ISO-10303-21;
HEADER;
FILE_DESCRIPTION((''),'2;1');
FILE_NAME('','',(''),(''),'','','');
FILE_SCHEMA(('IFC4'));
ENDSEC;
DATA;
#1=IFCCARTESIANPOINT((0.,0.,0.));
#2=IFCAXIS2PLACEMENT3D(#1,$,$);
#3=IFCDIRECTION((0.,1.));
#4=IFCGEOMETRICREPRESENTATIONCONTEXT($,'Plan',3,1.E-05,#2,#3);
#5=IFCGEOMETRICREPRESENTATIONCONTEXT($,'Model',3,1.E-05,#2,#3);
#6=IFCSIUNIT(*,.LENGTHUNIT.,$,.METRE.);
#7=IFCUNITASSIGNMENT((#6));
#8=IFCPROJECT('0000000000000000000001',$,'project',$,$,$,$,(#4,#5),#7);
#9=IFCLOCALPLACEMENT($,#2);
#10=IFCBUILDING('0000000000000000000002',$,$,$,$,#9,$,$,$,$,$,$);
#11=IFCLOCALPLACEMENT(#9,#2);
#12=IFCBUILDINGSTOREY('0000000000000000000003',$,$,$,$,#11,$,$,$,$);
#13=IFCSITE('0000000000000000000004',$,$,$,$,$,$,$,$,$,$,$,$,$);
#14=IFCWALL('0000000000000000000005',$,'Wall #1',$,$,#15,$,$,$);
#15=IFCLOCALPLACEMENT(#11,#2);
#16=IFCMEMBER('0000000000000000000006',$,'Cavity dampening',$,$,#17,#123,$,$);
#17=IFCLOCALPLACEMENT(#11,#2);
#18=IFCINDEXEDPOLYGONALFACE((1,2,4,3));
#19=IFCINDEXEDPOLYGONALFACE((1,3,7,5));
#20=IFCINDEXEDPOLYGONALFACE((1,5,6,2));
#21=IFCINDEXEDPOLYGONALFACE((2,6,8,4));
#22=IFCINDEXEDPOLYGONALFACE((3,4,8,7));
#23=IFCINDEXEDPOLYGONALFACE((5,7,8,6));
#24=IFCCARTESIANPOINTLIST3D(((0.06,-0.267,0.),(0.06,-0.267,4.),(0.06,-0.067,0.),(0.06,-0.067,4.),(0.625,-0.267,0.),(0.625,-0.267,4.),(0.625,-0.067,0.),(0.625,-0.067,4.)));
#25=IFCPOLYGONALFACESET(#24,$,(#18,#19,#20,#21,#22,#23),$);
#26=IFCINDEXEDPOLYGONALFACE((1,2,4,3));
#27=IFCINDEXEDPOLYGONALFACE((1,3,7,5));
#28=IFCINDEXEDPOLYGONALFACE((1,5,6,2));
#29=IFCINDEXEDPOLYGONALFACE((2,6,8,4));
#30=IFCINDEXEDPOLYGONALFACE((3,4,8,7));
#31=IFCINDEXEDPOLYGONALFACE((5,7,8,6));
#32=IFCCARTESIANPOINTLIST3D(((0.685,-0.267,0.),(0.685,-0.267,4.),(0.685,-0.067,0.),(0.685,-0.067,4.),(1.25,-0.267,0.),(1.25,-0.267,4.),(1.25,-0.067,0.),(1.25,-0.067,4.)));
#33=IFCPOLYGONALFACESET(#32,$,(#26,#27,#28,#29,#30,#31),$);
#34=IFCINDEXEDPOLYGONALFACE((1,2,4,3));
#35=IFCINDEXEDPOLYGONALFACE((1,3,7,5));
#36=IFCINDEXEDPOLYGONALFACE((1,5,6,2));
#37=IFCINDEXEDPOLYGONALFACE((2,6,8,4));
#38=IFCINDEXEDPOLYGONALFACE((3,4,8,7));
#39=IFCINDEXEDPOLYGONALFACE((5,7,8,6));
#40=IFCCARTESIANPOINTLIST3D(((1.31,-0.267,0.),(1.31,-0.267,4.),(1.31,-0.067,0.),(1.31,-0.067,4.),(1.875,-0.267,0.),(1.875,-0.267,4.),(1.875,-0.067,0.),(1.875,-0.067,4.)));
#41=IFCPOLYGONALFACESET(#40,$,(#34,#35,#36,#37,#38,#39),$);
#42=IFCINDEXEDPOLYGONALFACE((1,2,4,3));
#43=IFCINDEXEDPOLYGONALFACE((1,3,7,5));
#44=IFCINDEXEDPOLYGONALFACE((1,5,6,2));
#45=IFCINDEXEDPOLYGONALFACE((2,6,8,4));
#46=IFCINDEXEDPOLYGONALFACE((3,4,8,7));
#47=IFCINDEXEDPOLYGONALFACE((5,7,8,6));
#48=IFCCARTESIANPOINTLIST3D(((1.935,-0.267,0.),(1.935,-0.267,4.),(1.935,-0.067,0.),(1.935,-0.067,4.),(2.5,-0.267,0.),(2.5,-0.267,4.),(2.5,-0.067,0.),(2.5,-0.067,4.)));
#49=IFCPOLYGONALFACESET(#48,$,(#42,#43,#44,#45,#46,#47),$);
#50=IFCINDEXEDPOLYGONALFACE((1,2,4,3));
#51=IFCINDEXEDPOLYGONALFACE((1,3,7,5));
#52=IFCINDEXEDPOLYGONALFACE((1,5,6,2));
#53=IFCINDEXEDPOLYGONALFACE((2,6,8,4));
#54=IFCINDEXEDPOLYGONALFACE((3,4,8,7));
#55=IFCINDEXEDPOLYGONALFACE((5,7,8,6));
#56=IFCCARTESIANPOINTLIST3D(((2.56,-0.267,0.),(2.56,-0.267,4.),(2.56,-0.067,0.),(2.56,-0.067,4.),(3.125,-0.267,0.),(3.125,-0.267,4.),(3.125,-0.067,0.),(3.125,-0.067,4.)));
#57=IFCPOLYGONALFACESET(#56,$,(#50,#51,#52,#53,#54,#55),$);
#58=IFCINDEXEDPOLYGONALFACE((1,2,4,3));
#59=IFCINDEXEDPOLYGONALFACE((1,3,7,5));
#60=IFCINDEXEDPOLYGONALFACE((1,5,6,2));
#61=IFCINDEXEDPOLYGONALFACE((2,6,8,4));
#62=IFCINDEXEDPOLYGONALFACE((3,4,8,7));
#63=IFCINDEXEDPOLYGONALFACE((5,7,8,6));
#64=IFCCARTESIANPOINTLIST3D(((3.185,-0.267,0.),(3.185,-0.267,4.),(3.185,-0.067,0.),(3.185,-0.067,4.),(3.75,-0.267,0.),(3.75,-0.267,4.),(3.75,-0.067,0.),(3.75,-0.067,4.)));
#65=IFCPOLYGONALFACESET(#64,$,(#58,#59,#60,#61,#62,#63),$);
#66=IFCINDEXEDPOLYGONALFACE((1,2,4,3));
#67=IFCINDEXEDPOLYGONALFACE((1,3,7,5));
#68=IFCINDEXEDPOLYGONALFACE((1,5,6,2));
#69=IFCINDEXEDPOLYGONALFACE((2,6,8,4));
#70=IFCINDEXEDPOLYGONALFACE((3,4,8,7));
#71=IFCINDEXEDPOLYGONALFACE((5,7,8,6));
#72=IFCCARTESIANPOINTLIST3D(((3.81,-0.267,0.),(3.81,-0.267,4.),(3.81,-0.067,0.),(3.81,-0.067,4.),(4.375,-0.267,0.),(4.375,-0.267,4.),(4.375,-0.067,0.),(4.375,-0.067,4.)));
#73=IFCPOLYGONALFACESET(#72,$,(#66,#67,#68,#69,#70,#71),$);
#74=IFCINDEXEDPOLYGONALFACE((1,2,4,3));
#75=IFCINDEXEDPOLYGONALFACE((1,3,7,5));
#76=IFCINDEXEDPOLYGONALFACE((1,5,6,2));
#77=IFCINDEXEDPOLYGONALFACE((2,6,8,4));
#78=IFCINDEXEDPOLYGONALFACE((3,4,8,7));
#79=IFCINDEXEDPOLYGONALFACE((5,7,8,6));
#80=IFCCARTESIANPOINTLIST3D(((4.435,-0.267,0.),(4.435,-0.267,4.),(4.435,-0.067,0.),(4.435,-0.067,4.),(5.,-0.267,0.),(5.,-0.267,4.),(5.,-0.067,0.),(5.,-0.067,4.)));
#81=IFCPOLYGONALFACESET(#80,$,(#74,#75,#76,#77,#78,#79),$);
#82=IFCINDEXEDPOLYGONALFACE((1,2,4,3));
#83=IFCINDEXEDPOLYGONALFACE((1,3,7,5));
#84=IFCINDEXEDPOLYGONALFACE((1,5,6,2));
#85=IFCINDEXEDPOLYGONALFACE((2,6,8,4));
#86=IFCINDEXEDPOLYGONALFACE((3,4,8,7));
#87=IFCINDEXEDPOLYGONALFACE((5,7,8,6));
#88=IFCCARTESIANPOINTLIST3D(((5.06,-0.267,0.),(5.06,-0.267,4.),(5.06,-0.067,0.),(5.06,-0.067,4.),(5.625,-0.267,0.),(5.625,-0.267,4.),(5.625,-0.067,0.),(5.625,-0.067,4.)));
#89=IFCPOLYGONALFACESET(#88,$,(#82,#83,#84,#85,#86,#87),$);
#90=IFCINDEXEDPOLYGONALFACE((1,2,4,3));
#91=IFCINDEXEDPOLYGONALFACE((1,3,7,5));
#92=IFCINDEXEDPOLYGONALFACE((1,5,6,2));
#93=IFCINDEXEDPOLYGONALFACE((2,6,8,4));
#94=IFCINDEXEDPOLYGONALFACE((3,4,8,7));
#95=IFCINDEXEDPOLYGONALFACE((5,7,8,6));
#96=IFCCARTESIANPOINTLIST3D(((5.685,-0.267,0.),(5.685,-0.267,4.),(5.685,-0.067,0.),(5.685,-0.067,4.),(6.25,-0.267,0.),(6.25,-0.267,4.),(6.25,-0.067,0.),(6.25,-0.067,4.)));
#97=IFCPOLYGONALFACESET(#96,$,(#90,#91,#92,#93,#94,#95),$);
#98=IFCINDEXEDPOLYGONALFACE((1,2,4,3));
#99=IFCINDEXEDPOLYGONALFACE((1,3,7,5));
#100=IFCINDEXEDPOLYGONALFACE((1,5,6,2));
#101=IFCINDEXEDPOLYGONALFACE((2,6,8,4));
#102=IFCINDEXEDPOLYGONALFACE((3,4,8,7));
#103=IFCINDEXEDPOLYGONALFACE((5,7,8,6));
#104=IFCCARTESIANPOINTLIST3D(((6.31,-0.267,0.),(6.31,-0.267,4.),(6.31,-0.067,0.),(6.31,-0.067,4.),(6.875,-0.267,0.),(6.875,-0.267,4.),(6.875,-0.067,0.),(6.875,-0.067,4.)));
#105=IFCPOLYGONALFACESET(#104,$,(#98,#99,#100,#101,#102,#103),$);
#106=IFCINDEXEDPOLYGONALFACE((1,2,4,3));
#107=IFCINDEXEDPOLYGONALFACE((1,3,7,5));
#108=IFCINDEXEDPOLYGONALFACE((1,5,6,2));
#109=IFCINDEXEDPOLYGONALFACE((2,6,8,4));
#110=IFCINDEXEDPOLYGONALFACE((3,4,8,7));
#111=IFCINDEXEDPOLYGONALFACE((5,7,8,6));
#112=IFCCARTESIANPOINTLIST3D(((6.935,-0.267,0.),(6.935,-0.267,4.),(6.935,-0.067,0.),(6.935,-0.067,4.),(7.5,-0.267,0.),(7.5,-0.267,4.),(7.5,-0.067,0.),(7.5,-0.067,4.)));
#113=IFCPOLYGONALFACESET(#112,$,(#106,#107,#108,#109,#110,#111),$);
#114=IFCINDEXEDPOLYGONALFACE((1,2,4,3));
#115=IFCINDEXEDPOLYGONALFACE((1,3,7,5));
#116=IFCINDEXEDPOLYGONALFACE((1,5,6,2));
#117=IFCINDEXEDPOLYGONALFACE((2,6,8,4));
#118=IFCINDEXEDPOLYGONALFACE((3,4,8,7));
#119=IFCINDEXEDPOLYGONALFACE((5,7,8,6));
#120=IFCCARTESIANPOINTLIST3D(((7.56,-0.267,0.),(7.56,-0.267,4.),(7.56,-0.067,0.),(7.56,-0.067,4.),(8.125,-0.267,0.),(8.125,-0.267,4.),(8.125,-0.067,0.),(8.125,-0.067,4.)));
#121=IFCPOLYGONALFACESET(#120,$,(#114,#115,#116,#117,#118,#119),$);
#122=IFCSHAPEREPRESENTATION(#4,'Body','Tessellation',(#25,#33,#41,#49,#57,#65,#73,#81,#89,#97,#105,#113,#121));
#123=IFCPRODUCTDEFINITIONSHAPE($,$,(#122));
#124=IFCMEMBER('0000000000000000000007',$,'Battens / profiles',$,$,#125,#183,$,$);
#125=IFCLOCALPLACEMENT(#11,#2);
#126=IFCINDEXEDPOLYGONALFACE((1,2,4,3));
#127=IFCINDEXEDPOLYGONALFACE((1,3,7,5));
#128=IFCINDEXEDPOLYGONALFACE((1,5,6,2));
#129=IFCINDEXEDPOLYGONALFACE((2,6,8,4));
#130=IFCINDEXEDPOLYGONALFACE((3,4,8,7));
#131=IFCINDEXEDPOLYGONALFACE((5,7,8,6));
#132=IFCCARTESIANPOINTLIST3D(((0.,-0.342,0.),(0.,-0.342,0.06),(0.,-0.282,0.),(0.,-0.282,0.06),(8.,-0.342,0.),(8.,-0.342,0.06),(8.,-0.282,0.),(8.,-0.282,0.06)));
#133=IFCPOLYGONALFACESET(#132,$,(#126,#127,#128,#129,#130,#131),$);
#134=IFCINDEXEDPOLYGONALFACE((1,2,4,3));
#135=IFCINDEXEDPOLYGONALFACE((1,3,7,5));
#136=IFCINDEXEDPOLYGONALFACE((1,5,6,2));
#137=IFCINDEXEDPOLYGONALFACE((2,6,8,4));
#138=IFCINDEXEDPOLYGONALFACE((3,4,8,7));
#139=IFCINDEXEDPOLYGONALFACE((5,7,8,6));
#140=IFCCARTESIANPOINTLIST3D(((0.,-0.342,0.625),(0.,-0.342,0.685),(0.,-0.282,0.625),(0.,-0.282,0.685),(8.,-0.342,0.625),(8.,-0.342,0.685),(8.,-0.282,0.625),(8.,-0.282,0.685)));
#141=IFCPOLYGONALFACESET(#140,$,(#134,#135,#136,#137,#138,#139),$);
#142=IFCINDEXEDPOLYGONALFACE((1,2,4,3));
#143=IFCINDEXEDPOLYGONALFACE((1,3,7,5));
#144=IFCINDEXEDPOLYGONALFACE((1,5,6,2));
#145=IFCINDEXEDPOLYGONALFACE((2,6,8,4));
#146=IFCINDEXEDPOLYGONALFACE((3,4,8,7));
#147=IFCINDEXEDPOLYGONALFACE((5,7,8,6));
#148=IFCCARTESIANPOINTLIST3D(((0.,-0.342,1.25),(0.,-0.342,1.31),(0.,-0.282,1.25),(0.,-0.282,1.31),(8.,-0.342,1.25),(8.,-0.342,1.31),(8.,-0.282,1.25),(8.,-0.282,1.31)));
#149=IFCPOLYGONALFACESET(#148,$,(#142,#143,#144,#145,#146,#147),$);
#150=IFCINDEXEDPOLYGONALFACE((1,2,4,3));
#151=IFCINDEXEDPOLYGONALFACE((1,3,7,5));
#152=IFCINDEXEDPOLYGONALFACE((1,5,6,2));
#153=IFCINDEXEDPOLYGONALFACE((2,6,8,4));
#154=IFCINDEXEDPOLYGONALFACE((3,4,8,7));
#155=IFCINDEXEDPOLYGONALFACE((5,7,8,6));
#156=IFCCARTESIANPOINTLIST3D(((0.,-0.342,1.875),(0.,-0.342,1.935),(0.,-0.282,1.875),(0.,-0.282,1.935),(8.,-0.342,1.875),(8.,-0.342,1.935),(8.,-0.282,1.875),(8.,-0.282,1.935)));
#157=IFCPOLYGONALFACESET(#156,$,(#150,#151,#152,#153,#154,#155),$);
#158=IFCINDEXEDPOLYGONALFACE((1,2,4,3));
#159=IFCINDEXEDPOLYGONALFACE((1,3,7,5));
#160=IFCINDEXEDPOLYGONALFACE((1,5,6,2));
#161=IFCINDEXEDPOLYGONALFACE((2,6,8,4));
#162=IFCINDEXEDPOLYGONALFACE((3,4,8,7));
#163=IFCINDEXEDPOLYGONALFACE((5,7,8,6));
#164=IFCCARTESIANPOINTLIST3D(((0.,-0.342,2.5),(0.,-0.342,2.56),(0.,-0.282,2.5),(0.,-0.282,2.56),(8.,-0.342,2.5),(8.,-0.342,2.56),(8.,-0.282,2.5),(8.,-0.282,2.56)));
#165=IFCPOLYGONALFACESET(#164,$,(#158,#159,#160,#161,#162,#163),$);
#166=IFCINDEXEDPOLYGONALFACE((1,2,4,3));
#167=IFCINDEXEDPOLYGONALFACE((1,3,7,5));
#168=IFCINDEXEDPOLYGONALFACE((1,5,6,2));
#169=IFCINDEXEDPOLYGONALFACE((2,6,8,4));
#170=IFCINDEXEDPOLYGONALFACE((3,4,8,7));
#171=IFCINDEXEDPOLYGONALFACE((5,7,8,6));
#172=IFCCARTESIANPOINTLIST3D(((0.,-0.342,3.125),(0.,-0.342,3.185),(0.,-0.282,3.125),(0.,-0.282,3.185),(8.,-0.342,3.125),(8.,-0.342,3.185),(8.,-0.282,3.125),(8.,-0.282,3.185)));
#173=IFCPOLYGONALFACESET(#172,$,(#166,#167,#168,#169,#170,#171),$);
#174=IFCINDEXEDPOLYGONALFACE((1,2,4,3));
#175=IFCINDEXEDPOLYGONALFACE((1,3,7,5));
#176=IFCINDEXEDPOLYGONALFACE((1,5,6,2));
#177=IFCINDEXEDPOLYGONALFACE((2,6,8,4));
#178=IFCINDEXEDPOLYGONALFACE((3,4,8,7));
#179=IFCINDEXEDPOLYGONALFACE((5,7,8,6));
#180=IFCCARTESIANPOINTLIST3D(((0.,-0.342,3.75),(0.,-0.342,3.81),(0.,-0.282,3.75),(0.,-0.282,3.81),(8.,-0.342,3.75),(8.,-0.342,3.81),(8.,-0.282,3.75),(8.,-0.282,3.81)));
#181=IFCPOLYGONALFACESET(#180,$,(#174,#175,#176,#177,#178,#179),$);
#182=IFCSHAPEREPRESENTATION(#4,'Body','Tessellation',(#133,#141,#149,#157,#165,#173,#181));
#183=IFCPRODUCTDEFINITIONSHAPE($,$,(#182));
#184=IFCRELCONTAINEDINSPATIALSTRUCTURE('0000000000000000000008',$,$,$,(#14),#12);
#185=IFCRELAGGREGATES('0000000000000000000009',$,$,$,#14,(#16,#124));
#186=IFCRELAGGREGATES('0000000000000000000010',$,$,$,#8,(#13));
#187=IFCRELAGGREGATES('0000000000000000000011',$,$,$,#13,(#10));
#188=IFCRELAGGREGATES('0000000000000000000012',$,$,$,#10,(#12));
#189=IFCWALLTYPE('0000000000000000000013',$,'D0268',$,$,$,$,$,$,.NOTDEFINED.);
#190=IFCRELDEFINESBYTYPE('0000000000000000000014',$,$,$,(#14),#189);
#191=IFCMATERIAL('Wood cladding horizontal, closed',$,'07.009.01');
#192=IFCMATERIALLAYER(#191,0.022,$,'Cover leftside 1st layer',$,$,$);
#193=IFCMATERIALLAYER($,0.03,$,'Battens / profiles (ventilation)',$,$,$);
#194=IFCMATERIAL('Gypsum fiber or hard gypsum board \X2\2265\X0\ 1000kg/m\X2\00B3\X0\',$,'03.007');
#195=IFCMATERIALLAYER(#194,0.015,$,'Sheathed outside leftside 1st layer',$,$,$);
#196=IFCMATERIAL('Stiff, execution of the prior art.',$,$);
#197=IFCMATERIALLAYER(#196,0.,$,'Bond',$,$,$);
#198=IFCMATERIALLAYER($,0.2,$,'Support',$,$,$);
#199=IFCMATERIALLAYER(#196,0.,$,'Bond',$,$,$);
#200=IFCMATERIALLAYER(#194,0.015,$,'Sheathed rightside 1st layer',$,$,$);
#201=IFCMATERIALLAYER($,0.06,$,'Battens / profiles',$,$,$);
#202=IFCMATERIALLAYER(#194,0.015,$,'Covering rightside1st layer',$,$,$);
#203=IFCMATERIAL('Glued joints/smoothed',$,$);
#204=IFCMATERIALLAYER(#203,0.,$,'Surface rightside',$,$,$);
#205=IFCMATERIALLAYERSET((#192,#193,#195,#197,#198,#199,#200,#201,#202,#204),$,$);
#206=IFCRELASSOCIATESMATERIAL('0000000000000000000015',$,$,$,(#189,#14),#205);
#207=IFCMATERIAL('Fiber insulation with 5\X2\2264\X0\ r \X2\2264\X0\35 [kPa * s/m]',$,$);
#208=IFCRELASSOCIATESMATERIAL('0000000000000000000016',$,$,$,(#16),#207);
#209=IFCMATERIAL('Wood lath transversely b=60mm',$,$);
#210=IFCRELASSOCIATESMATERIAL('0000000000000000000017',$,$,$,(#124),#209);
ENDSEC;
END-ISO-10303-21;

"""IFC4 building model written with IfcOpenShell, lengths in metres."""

from ifc_helpers import new_model, si_unit, direction, frame, frame_2d, origin, place, context, project, spatial, rectangle, extrude, material, layer, layer_set, type_object, element, aggregate, save


model = new_model("IFC4")

# Units and contexts
plan_context = context("Plan", 3, precision=1e-05, world=origin(), true_north=direction((0.0, 1.0)))
model_context = context("Model", 3, precision=1e-05, world=origin(), true_north=direction((0.0, 1.0)))
ifc_project = project(units=[si_unit("LENGTHUNIT", "METRE")], contexts=[plan_context, model_context])

# Site, building, storey
site = spatial("IfcSite", under=ifc_project)
building_placement = place(None, origin())
building = spatial("IfcBuilding", under=site, at=building_placement)
storey_placement = place(building_placement, origin())
storey = spatial("IfcBuildingStorey", under=building, at=storey_placement)

# Wall, members
ifc_material_1 = material(Name="Wood cladding horizontal, closed", Category="07.009.01")
ifc_layer_1 = layer(ifc_material_1, 0.022, Name="Cover leftside 1st layer")
ifc_layer_2 = layer(None, 0.03, Name="Battens / profiles (ventilation)")
ifc_material_2 = material(Name="Gypsum fiber or hard gypsum board ≥ 1000kg/m³", Category="03.007")
ifc_layer_3 = layer(ifc_material_2, 0.015, Name="Sheathed outside leftside 1st layer")
ifc_material_3 = material(Name="Stiff, execution of the prior art.")
ifc_layer_4 = layer(ifc_material_3, 0.0, Name="Bond")
ifc_layer_5 = layer(None, 0.2, Name="Support")
ifc_layer_6 = layer(ifc_material_3, 0.0, Name="Bond")
ifc_layer_7 = layer(ifc_material_2, 0.015, Name="Sheathed rightside 1st layer")
ifc_layer_8 = layer(None, 0.06, Name="Battens / profiles")
ifc_layer_9 = layer(ifc_material_2, 0.015, Name="Covering rightside1st layer")
ifc_material_4 = material(Name="Glued joints/smoothed")
ifc_layer_10 = layer(ifc_material_4, 0.0, Name="Surface rightside")
ifc_layer_set = layer_set([ifc_layer_1, ifc_layer_2, ifc_layer_3, ifc_layer_4, ifc_layer_5, ifc_layer_6, ifc_layer_7, ifc_layer_8, ifc_layer_9, ifc_layer_10])
wall_type = type_object("IfcWallType", Name="D0268", PredefinedType="NOTDEFINED", material=ifc_layer_set)
wall_placement = place(None, frame((0.0, 0.0, 0.0), z_axis=(0.0, -1.0, 0.0), x_axis=(1.0, 0.0, 0.0)))
wall = element("IfcWall", 1, at=wall_placement, inside=storey, type_object=wall_type, material=ifc_layer_set, Name="Wall #1")
ifc_material_5 = material(Name="Fiber insulation with 5≤ r ≤35 [kPa * s/m]")
member_1_placement = place(wall_placement, origin())
member_1 = element("IfcMember", 2, at=member_1_placement, material=ifc_material_5, Name="Cavity dampening", context=plan_context, shape_type="SweptSolid", body=[
    extrude(rectangle(XDim=0.565, YDim=0.2, at=frame_2d((0.2825, 0.1), x_axis=(1.0, 0.0))), frame((0.06, 4.0, 0.067), z_axis=(0.0, -1.0, 0.0), x_axis=(1.0, 0.0, 0.0)), (0.0, 0.0, 1.0), 4.0),
    extrude(rectangle(XDim=0.565, YDim=0.2, at=frame_2d((0.2825, 0.1), x_axis=(1.0, 0.0))), frame((0.685, 4.0, 0.067), z_axis=(0.0, -1.0, 0.0), x_axis=(1.0, 0.0, 0.0)), (0.0, 0.0, 1.0), 4.0),
    extrude(rectangle(XDim=0.565, YDim=0.2, at=frame_2d((0.2825, 0.1), x_axis=(1.0, 0.0))), frame((1.31, 4.0, 0.067), z_axis=(0.0, -1.0, 0.0), x_axis=(1.0, 0.0, 0.0)), (0.0, 0.0, 1.0), 4.0),
    extrude(rectangle(XDim=0.565, YDim=0.2, at=frame_2d((0.2825, 0.1), x_axis=(1.0, 0.0))), frame((1.935, 4.0, 0.067), z_axis=(0.0, -1.0, 0.0), x_axis=(1.0, 0.0, 0.0)), (0.0, 0.0, 1.0), 4.0),
    extrude(rectangle(XDim=0.565, YDim=0.2, at=frame_2d((0.2825, 0.1), x_axis=(1.0, 0.0))), frame((2.56, 4.0, 0.067), z_axis=(0.0, -1.0, 0.0), x_axis=(1.0, 0.0, 0.0)), (0.0, 0.0, 1.0), 4.0),
    extrude(rectangle(XDim=0.565, YDim=0.2, at=frame_2d((0.2825, 0.1), x_axis=(1.0, 0.0))), frame((3.185, 4.0, 0.067), z_axis=(0.0, -1.0, 0.0), x_axis=(1.0, 0.0, 0.0)), (0.0, 0.0, 1.0), 4.0),
    extrude(rectangle(XDim=0.565, YDim=0.2, at=frame_2d((0.2825, 0.1), x_axis=(1.0, 0.0))), frame((3.81, 4.0, 0.067), z_axis=(0.0, -1.0, 0.0), x_axis=(1.0, 0.0, 0.0)), (0.0, 0.0, 1.0), 4.0),
    extrude(rectangle(XDim=0.565, YDim=0.2, at=frame_2d((0.2825, 0.1), x_axis=(1.0, 0.0))), frame((4.435, 4.0, 0.067), z_axis=(0.0, -1.0, 0.0), x_axis=(1.0, 0.0, 0.0)), (0.0, 0.0, 1.0), 4.0),
    extrude(rectangle(XDim=0.565, YDim=0.2, at=frame_2d((0.2825, 0.1), x_axis=(1.0, 0.0))), frame((5.06, 4.0, 0.067), z_axis=(0.0, -1.0, 0.0), x_axis=(1.0, 0.0, 0.0)), (0.0, 0.0, 1.0), 4.0),
    extrude(rectangle(XDim=0.565, YDim=0.2, at=frame_2d((0.2825, 0.1), x_axis=(1.0, 0.0))), frame((5.685, 4.0, 0.067), z_axis=(0.0, -1.0, 0.0), x_axis=(1.0, 0.0, 0.0)), (0.0, 0.0, 1.0), 4.0),
    extrude(rectangle(XDim=0.565, YDim=0.2, at=frame_2d((0.2825, 0.1), x_axis=(1.0, 0.0))), frame((6.31, 4.0, 0.067), z_axis=(0.0, -1.0, 0.0), x_axis=(1.0, 0.0, 0.0)), (0.0, 0.0, 1.0), 4.0),
    extrude(rectangle(XDim=0.565, YDim=0.2, at=frame_2d((0.2825, 0.1), x_axis=(1.0, 0.0))), frame((6.935, 4.0, 0.067), z_axis=(0.0, -1.0, 0.0), x_axis=(1.0, 0.0, 0.0)), (0.0, 0.0, 1.0), 4.0),
    extrude(rectangle(XDim=0.565, YDim=0.2, at=frame_2d((0.2825, 0.1), x_axis=(1.0, 0.0))), frame((7.56, 4.0, 0.067), z_axis=(0.0, -1.0, 0.0), x_axis=(1.0, 0.0, 0.0)), (0.0, 0.0, 1.0), 4.0),
])
ifc_material_6 = material(Name="Wood lath transversely b=60mm")
member_2_placement = place(wall_placement, origin())
member_2 = element("IfcMember", 3, at=member_2_placement, material=ifc_material_6, Name="Battens / profiles", context=plan_context, shape_type="SweptSolid", body=[
    extrude(rectangle(XDim=0.06, YDim=0.06, at=frame_2d((0.03, 0.03), x_axis=(1.0, 0.0))), frame((0.0, 0.0, 0.282), z_axis=(1.0, 0.0, 0.0), x_axis=(0.0, 1.0, 0.0)), (0.0, 0.0, 1.0), 8.0),
    extrude(rectangle(XDim=0.06, YDim=0.06, at=frame_2d((0.03, 0.03), x_axis=(1.0, 0.0))), frame((0.0, 0.625, 0.282), z_axis=(1.0, 0.0, 0.0), x_axis=(0.0, 1.0, 0.0)), (0.0, 0.0, 1.0), 8.0),
    extrude(rectangle(XDim=0.06, YDim=0.06, at=frame_2d((0.03, 0.03), x_axis=(1.0, 0.0))), frame((0.0, 1.25, 0.282), z_axis=(1.0, 0.0, 0.0), x_axis=(0.0, 1.0, 0.0)), (0.0, 0.0, 1.0), 8.0),
    extrude(rectangle(XDim=0.06, YDim=0.06, at=frame_2d((0.03, 0.03), x_axis=(1.0, 0.0))), frame((0.0, 1.875, 0.282), z_axis=(1.0, 0.0, 0.0), x_axis=(0.0, 1.0, 0.0)), (0.0, 0.0, 1.0), 8.0),
    extrude(rectangle(XDim=0.06, YDim=0.06, at=frame_2d((0.03, 0.03), x_axis=(1.0, 0.0))), frame((0.0, 2.5, 0.282), z_axis=(1.0, 0.0, 0.0), x_axis=(0.0, 1.0, 0.0)), (0.0, 0.0, 1.0), 8.0),
    extrude(rectangle(XDim=0.06, YDim=0.06, at=frame_2d((0.03, 0.03), x_axis=(1.0, 0.0))), frame((0.0, 3.125, 0.282), z_axis=(1.0, 0.0, 0.0), x_axis=(0.0, 1.0, 0.0)), (0.0, 0.0, 1.0), 8.0),
    extrude(rectangle(XDim=0.06, YDim=0.06, at=frame_2d((0.03, 0.03), x_axis=(1.0, 0.0))), frame((0.0, 3.75, 0.282), z_axis=(1.0, 0.0, 0.0), x_axis=(0.0, 1.0, 0.0)), (0.0, 0.0, 1.0), 8.0),
])
aggregate(wall, [member_1, member_2])

save(model, "model.ifc")
